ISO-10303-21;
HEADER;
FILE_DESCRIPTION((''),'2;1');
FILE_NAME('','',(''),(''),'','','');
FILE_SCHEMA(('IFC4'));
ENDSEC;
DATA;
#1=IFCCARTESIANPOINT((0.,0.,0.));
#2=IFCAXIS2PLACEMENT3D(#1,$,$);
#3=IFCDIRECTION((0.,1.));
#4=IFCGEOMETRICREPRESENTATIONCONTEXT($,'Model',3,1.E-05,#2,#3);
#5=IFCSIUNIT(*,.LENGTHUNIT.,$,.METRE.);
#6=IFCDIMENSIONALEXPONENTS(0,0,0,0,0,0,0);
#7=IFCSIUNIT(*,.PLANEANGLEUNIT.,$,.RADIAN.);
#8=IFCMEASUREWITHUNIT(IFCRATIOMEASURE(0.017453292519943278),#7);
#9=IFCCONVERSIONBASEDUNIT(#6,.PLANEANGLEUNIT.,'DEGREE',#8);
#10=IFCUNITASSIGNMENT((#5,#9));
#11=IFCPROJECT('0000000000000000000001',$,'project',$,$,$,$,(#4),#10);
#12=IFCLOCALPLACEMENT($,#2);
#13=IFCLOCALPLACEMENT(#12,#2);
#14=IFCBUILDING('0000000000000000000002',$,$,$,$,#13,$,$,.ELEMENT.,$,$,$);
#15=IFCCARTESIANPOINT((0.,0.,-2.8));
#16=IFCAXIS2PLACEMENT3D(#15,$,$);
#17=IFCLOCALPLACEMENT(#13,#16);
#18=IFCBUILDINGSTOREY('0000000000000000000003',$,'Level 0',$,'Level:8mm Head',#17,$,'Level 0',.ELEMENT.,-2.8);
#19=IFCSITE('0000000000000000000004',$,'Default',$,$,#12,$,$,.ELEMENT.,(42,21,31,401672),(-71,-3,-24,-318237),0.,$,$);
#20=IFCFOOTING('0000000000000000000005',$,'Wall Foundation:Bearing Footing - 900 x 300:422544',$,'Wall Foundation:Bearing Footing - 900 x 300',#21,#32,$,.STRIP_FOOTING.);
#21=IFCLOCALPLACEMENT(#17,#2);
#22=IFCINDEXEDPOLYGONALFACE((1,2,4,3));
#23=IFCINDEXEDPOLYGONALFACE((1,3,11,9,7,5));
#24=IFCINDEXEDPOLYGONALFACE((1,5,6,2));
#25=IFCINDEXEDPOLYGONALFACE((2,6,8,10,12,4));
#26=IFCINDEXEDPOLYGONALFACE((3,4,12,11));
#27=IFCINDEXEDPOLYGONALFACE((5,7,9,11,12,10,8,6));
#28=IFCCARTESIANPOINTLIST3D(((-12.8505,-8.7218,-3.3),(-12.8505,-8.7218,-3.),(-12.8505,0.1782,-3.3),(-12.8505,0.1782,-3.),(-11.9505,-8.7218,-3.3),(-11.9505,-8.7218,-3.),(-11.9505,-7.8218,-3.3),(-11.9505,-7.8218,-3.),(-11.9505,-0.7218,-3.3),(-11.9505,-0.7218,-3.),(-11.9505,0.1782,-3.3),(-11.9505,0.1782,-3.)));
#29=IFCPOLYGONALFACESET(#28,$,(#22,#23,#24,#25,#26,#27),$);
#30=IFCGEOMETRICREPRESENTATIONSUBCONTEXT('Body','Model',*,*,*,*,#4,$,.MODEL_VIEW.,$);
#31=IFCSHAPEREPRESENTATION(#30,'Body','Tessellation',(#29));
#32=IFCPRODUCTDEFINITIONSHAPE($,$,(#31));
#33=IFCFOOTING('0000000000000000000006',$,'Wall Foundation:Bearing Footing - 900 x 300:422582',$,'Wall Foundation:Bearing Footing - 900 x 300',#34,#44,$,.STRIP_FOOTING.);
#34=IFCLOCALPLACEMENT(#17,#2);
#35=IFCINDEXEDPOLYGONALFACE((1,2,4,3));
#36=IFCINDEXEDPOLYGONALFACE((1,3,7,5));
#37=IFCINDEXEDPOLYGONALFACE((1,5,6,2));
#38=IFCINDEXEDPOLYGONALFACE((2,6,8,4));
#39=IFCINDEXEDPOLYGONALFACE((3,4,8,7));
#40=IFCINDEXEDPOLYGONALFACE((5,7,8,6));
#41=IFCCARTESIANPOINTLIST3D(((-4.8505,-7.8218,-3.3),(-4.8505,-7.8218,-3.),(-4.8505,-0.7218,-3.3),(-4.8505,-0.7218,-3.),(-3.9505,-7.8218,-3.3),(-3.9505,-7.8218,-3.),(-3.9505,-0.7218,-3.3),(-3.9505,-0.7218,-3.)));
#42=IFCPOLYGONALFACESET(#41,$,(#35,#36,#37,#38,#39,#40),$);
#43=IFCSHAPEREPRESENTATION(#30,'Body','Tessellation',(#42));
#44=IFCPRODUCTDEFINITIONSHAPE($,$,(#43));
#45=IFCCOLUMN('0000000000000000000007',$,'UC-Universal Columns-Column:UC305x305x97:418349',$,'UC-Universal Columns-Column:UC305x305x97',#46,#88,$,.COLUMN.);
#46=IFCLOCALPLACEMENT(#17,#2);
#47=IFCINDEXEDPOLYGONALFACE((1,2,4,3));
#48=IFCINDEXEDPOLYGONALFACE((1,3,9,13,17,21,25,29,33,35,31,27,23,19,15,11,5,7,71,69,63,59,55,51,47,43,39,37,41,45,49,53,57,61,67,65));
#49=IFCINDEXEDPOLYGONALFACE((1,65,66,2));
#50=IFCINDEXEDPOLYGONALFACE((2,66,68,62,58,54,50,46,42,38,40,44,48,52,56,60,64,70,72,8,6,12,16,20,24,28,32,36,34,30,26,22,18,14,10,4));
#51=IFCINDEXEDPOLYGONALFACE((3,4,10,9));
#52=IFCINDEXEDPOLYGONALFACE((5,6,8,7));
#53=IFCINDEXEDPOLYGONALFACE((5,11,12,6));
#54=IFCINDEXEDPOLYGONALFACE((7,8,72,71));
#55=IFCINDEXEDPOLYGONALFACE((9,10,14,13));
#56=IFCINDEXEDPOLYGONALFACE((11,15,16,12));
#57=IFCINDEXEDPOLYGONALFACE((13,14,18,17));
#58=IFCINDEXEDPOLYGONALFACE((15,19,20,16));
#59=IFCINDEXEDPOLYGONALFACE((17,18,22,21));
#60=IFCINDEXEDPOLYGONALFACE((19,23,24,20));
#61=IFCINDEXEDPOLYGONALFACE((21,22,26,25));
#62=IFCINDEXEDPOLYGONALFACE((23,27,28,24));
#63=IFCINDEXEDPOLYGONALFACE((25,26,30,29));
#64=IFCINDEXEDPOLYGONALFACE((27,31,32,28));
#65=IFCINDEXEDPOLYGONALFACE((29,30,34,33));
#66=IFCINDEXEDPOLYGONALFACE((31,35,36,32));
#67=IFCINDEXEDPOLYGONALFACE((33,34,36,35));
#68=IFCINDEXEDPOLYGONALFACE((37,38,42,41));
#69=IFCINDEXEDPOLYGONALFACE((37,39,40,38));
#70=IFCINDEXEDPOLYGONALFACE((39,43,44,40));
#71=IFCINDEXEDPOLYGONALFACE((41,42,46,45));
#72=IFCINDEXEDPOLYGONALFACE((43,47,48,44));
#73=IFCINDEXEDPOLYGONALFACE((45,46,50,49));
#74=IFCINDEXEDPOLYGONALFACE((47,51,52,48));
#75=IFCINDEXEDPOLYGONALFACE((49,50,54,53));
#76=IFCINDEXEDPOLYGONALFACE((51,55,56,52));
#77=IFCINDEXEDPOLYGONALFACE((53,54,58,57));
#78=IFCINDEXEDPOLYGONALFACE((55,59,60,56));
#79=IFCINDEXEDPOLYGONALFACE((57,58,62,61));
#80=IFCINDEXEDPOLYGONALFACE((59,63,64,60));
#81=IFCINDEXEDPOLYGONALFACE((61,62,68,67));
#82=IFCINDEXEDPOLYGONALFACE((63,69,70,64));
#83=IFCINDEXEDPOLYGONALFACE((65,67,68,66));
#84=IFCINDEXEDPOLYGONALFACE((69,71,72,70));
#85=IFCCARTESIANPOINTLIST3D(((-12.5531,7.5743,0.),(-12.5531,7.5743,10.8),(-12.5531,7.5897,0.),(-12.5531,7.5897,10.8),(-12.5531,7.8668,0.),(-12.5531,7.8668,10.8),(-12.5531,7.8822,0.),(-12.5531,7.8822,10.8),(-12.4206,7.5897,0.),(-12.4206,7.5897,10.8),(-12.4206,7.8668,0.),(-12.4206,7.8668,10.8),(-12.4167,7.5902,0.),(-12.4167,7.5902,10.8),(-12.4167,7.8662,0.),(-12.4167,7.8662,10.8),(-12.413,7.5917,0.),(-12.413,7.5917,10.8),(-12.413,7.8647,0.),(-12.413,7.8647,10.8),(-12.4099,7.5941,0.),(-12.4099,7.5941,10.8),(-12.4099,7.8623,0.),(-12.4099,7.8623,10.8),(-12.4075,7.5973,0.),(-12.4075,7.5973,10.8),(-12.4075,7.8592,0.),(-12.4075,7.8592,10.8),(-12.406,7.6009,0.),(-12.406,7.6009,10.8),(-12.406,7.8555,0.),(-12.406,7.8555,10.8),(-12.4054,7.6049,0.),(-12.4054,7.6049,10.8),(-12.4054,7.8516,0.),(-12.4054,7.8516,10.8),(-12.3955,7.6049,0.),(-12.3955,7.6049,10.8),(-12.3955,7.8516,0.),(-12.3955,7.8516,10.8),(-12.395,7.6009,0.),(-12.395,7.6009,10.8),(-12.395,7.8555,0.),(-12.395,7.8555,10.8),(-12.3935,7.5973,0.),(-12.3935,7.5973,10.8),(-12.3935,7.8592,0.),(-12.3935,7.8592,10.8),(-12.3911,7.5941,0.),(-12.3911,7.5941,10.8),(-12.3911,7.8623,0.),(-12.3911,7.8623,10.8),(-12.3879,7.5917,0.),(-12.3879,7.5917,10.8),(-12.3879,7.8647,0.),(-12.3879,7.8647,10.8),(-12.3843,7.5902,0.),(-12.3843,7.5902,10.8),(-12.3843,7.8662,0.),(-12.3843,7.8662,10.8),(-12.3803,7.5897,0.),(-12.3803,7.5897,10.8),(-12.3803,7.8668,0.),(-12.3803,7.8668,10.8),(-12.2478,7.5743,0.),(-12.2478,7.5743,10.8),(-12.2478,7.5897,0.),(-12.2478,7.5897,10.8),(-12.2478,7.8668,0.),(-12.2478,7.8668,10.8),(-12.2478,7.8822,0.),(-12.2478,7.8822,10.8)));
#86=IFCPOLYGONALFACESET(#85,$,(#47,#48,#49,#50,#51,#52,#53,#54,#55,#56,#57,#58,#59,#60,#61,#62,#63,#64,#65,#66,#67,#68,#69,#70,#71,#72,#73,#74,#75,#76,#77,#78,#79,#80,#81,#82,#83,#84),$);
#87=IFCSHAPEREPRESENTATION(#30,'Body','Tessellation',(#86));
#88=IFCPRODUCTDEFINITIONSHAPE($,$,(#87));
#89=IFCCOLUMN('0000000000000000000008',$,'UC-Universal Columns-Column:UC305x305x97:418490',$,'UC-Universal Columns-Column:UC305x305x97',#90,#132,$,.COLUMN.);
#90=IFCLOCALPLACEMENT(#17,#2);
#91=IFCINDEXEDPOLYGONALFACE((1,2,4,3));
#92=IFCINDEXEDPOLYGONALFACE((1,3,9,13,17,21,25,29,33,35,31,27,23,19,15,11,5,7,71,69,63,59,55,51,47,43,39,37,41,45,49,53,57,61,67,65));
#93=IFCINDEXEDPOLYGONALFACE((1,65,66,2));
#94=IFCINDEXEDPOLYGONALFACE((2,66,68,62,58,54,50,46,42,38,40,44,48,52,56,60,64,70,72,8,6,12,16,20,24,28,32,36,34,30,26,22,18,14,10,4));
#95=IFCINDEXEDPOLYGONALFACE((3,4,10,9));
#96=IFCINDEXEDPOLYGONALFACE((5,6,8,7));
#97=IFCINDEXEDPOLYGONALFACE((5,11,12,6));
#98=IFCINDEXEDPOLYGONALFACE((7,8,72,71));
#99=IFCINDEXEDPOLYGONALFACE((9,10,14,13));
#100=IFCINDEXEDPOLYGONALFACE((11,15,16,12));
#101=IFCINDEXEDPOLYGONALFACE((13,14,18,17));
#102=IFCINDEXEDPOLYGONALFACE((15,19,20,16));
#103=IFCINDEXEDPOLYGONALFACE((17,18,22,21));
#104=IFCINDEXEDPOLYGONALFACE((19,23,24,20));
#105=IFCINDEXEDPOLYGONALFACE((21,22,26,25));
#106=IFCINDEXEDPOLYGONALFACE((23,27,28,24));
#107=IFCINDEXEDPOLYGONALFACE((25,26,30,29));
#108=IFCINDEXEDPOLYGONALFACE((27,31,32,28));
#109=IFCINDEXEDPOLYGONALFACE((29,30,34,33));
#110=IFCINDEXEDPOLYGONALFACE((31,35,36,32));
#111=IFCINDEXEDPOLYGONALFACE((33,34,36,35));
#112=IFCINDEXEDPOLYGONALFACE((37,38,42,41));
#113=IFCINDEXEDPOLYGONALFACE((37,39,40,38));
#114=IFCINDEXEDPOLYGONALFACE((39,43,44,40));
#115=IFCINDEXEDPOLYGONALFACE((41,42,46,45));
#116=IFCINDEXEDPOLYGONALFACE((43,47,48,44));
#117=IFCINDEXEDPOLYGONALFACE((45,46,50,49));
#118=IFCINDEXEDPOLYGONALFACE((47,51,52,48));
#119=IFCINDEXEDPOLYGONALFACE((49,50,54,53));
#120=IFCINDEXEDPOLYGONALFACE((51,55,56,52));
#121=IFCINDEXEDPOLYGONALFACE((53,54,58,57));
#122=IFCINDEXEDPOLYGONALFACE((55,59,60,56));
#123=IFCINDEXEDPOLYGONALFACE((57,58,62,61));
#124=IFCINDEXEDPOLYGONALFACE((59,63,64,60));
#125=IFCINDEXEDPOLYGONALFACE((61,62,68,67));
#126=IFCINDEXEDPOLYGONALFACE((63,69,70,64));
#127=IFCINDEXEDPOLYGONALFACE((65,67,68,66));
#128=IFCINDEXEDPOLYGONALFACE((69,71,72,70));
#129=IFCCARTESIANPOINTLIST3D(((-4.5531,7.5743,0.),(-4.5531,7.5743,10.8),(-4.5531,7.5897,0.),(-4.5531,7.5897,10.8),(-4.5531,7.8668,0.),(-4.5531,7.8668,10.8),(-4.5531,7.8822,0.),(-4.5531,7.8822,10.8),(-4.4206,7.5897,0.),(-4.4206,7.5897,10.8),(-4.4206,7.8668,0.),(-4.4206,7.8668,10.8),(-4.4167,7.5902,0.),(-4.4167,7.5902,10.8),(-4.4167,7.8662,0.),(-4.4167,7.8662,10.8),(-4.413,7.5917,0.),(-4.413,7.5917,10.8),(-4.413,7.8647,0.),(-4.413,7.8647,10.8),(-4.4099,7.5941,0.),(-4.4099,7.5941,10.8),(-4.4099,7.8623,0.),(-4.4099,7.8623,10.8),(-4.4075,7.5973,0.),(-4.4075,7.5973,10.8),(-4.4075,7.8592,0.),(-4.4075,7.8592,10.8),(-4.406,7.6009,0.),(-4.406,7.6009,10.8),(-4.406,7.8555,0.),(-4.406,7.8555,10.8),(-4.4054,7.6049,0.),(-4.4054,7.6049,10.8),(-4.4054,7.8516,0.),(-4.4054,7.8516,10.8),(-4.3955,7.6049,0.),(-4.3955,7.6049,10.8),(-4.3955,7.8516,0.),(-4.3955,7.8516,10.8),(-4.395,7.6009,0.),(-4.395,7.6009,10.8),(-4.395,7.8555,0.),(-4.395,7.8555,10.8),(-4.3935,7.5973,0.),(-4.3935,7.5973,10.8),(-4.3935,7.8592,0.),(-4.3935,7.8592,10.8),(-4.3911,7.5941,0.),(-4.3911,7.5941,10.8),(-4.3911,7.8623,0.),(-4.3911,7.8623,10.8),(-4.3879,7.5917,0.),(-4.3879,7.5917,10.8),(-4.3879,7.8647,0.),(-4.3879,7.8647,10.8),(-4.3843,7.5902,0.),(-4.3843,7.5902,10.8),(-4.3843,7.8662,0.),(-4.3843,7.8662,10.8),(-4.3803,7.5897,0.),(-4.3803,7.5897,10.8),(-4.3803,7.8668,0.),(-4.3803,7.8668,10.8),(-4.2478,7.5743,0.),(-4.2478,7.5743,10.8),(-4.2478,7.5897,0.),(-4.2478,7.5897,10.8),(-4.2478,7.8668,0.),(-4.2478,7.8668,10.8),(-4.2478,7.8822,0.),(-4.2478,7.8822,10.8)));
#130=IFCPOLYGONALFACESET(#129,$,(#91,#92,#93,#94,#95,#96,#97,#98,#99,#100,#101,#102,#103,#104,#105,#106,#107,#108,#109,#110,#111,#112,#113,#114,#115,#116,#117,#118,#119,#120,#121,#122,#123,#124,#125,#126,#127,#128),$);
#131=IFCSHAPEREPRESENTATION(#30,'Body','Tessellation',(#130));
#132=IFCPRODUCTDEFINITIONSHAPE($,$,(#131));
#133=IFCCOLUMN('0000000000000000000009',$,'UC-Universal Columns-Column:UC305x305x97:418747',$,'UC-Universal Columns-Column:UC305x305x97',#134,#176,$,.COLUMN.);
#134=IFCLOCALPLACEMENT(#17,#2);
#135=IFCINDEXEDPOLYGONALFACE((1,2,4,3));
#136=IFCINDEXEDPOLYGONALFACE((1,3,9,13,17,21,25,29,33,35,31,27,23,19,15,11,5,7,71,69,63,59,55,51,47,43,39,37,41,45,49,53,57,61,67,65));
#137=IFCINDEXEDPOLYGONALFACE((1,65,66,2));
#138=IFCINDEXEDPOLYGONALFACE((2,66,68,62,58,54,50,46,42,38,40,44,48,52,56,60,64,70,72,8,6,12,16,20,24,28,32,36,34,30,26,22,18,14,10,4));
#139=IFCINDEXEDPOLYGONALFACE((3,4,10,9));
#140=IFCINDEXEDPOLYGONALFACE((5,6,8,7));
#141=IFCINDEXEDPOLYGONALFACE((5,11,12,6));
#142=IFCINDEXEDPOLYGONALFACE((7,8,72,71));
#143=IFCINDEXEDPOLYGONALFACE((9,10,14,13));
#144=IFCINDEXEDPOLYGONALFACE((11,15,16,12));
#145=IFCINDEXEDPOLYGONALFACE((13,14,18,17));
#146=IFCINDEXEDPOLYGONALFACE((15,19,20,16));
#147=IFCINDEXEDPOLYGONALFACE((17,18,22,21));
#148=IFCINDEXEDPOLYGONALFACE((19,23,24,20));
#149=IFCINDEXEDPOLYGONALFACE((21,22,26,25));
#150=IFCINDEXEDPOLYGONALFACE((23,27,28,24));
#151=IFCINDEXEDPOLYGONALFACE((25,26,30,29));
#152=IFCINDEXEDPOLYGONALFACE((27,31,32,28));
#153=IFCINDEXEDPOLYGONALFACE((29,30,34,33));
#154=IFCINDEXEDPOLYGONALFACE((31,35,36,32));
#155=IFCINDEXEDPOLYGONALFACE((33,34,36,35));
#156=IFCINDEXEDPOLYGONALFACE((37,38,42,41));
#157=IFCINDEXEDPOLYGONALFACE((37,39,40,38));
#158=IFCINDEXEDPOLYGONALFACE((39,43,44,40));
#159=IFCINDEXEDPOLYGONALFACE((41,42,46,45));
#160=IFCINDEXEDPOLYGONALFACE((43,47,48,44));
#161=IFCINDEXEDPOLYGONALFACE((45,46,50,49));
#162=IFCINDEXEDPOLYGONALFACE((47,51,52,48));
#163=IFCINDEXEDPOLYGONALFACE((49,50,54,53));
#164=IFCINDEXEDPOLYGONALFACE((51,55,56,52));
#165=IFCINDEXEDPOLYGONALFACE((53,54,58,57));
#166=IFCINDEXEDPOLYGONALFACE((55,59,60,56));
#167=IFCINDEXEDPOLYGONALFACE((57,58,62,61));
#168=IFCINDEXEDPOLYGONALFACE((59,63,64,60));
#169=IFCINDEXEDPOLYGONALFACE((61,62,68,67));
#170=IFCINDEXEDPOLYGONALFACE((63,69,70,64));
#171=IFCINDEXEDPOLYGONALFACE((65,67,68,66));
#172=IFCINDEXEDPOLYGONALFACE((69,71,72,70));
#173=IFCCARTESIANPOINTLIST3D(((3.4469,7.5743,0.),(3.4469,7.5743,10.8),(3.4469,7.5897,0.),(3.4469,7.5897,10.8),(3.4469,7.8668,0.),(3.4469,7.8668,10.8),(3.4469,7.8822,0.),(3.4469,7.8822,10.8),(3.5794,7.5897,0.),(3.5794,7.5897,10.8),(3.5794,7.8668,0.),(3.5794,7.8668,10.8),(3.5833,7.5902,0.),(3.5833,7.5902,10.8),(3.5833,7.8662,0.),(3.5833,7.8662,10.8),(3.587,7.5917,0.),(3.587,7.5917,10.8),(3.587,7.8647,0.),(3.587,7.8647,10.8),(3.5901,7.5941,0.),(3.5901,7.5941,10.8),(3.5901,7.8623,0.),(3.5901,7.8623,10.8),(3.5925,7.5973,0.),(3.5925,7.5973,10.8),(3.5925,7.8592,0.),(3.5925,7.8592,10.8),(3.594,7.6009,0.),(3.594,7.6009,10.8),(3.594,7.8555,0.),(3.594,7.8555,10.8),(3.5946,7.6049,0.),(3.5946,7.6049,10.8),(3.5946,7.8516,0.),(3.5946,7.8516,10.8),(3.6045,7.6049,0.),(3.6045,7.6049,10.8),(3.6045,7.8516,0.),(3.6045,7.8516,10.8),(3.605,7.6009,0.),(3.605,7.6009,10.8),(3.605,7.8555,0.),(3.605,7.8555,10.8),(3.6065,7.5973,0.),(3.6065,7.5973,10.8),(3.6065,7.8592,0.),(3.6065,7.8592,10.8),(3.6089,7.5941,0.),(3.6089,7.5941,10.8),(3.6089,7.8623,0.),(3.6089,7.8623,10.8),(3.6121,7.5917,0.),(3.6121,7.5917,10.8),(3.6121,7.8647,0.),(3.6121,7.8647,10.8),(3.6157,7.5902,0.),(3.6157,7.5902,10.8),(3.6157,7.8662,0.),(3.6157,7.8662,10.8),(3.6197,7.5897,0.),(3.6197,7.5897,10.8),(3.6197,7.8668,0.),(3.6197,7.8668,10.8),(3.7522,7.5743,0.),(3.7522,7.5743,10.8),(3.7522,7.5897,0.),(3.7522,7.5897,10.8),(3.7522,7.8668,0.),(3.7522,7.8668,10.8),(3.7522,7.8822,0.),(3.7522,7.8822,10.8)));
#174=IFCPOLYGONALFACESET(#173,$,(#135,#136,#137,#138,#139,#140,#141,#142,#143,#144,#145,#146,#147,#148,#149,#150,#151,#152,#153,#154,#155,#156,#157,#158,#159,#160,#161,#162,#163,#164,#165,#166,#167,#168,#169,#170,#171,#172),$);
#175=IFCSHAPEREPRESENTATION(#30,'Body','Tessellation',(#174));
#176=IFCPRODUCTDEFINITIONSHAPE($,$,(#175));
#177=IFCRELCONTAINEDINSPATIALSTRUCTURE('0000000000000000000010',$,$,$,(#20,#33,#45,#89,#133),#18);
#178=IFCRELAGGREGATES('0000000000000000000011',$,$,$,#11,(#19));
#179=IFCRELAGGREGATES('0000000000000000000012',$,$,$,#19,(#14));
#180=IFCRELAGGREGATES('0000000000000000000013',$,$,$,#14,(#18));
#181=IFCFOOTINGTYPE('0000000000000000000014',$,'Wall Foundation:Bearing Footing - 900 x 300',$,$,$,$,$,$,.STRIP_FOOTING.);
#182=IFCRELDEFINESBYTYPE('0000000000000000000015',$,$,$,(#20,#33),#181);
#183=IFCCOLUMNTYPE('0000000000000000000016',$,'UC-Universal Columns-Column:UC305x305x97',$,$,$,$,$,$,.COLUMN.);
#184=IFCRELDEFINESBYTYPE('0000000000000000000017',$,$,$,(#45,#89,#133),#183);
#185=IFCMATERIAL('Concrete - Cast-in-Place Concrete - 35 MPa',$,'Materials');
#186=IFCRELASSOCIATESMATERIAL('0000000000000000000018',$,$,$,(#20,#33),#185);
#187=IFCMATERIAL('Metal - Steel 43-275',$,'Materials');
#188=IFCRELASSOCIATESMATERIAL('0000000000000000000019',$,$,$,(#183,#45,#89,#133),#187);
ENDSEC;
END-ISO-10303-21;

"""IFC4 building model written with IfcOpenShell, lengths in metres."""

from ifc_helpers import new_model, entity, si_unit, converted_unit, direction, frame, origin, place, context, subcontext, project, spatial, line, arc, indexed_curve, outline, extrude, source, transform, mapped, material, type_object, type_shapes, element, save


model = new_model("IFC4")

# Units and contexts
model_context = context("Model", 3, precision=1e-05, world=origin(), true_north=direction((0.0, 1.0)))
body_context = subcontext(model_context, "Body", "Model", "MODEL_VIEW")
ifc_project = project(units=[si_unit("LENGTHUNIT", "METRE"), converted_unit("PLANEANGLEUNIT", "DEGREE", entity("IfcRatioMeasure", 0.017453292519943278), si_unit("PLANEANGLEUNIT", "RADIAN"), dimensions=[0, 0, 0, 0, 0, 0, 0])], contexts=[model_context])

# Site, building, storey
site_placement = place(None, origin())
site = spatial("IfcSite", under=ifc_project, at=site_placement, Name="Default", CompositionType="ELEMENT", RefLatitude=(42, 21, 31, 401672), RefLongitude=(-71, -3, -24, -318237), RefElevation=0.0)
building_placement = place(site_placement, origin())
building = spatial("IfcBuilding", under=site, at=building_placement, CompositionType="ELEMENT")
storey_placement = place(building_placement, frame((0.0, 0.0, -2.8)))
storey = spatial("IfcBuildingStorey", under=building, at=storey_placement, Name="Level 0", ObjectType="Level:8mm Head", LongName="Level 0", CompositionType="ELEMENT", Elevation=-2.8)

# Footings
ifc_material_1 = material(Name="Concrete - Cast-in-Place Concrete - 35 MPa", Category="Materials")
footing_type = type_object("IfcFootingType", Name="Wall Foundation:Bearing Footing - 900 x 300", PredefinedType="STRIP_FOOTING")
footing_1_placement = place(storey_placement, origin())
element("IfcFooting", 1, at=footing_1_placement, inside=storey, type_object=footing_type, material=ifc_material_1, Name="Wall Foundation:Bearing Footing - 900 x 300:422544", ObjectType="Wall Foundation:Bearing Footing - 900 x 300", PredefinedType="STRIP_FOOTING", context=body_context, shape_type="SweptSolid", body=[
    extrude(outline(indexed_curve([(-4.45, -0.3), (-3.55, -0.3), (3.55, -0.3), (4.45, -0.3), (4.45, 0.6), (-4.45, 0.6), (-4.45, -0.3)], self_intersect=False)), frame((-12.2505, -4.2718, -3.3), z_axis=(0.0, 0.0, 1.0), x_axis=(0.0, 1.0, 0.0)), (0.0, 0.0, 1.0), 0.3),
])
footing_2_placement = place(storey_placement, origin())
element("IfcFooting", 2, at=footing_2_placement, inside=storey, type_object=footing_type, material=ifc_material_1, Name="Wall Foundation:Bearing Footing - 900 x 300:422582", ObjectType="Wall Foundation:Bearing Footing - 900 x 300", PredefinedType="STRIP_FOOTING", context=body_context, shape_type="SweptSolid", body=[
    extrude(outline(indexed_curve([(-3.55, -0.45), (3.55, -0.45), (3.55, 0.45), (-3.55, 0.45), (-3.55, -0.45)], self_intersect=False)), frame((-4.4005, -4.2718, -3.3), z_axis=(0.0, 0.0, 1.0), x_axis=(0.0, 1.0, 0.0)), (0.0, 0.0, 1.0), 0.3),
])

# Columns
ifc_material_2 = material(Name="Metal - Steel 43-275", Category="Materials")
column_type = type_object("IfcColumnType", Name="UC-Universal Columns-Column:UC305x305x97", PredefinedType="COLUMN", material=ifc_material_2)
shared_shape = source(origin(), body_context, "Body", "SweptSolid", [
    extrude(outline(indexed_curve([(-0.154, -0.1526), (-0.1385, -0.1526), (-0.1385, -0.0202), (-0.1341, -0.0094), (-0.1234, -0.0049), (0.1233, -0.0049), (0.1341, -0.0094), (0.1385, -0.0201), (0.1385, -0.1526), (0.154, -0.1526), (0.154, 0.1526), (0.1385, 0.1526), (0.1385, 0.0202), (0.1341, 0.0094), (0.1234, 0.005), (-0.1233, 0.005), (-0.1341, 0.0094), (-0.1385, 0.0202), (-0.1385, 0.1526), (-0.154, 0.1526)], segments=[line(1, 2, 3), arc(3, 4, 5), line(5, 6), arc(6, 7, 8), line(8, 9, 10, 11, 12, 13), arc(13, 14, 15), line(15, 16), arc(16, 17, 18), line(18, 19, 20, 1)], self_intersect=False)), frame((0.0, 0.0, -2.8), z_axis=(0.0, 0.0, 1.0), x_axis=(0.0, -1.0, 0.0)), (0.0, 0.0, 1.0), 10.8),
])
type_shapes(column_type, [shared_shape])
for number, where, name in (
    (3, (-12.4005, 7.7282, 2.8), "UC-Universal Columns-Column:UC305x305x97:418349"),
    (4, (-4.4005, 7.7282, 2.8), "UC-Universal Columns-Column:UC305x305x97:418490"),
    (5, (3.5995, 7.7282, 2.8), "UC-Universal Columns-Column:UC305x305x97:418747"),
):
    element("IfcColumn", number, at=place(storey_placement, frame(where)), inside=storey, type_object=column_type, material=ifc_material_2, Name=name, ObjectType="UC-Universal Columns-Column:UC305x305x97", PredefinedType="COLUMN", context=body_context, shape_type="MappedRepresentation", body=[
        mapped(shared_shape, transform((0.0, 0.0, 0.0), scale=1.0)),
    ])

save(model, "model.ifc")
